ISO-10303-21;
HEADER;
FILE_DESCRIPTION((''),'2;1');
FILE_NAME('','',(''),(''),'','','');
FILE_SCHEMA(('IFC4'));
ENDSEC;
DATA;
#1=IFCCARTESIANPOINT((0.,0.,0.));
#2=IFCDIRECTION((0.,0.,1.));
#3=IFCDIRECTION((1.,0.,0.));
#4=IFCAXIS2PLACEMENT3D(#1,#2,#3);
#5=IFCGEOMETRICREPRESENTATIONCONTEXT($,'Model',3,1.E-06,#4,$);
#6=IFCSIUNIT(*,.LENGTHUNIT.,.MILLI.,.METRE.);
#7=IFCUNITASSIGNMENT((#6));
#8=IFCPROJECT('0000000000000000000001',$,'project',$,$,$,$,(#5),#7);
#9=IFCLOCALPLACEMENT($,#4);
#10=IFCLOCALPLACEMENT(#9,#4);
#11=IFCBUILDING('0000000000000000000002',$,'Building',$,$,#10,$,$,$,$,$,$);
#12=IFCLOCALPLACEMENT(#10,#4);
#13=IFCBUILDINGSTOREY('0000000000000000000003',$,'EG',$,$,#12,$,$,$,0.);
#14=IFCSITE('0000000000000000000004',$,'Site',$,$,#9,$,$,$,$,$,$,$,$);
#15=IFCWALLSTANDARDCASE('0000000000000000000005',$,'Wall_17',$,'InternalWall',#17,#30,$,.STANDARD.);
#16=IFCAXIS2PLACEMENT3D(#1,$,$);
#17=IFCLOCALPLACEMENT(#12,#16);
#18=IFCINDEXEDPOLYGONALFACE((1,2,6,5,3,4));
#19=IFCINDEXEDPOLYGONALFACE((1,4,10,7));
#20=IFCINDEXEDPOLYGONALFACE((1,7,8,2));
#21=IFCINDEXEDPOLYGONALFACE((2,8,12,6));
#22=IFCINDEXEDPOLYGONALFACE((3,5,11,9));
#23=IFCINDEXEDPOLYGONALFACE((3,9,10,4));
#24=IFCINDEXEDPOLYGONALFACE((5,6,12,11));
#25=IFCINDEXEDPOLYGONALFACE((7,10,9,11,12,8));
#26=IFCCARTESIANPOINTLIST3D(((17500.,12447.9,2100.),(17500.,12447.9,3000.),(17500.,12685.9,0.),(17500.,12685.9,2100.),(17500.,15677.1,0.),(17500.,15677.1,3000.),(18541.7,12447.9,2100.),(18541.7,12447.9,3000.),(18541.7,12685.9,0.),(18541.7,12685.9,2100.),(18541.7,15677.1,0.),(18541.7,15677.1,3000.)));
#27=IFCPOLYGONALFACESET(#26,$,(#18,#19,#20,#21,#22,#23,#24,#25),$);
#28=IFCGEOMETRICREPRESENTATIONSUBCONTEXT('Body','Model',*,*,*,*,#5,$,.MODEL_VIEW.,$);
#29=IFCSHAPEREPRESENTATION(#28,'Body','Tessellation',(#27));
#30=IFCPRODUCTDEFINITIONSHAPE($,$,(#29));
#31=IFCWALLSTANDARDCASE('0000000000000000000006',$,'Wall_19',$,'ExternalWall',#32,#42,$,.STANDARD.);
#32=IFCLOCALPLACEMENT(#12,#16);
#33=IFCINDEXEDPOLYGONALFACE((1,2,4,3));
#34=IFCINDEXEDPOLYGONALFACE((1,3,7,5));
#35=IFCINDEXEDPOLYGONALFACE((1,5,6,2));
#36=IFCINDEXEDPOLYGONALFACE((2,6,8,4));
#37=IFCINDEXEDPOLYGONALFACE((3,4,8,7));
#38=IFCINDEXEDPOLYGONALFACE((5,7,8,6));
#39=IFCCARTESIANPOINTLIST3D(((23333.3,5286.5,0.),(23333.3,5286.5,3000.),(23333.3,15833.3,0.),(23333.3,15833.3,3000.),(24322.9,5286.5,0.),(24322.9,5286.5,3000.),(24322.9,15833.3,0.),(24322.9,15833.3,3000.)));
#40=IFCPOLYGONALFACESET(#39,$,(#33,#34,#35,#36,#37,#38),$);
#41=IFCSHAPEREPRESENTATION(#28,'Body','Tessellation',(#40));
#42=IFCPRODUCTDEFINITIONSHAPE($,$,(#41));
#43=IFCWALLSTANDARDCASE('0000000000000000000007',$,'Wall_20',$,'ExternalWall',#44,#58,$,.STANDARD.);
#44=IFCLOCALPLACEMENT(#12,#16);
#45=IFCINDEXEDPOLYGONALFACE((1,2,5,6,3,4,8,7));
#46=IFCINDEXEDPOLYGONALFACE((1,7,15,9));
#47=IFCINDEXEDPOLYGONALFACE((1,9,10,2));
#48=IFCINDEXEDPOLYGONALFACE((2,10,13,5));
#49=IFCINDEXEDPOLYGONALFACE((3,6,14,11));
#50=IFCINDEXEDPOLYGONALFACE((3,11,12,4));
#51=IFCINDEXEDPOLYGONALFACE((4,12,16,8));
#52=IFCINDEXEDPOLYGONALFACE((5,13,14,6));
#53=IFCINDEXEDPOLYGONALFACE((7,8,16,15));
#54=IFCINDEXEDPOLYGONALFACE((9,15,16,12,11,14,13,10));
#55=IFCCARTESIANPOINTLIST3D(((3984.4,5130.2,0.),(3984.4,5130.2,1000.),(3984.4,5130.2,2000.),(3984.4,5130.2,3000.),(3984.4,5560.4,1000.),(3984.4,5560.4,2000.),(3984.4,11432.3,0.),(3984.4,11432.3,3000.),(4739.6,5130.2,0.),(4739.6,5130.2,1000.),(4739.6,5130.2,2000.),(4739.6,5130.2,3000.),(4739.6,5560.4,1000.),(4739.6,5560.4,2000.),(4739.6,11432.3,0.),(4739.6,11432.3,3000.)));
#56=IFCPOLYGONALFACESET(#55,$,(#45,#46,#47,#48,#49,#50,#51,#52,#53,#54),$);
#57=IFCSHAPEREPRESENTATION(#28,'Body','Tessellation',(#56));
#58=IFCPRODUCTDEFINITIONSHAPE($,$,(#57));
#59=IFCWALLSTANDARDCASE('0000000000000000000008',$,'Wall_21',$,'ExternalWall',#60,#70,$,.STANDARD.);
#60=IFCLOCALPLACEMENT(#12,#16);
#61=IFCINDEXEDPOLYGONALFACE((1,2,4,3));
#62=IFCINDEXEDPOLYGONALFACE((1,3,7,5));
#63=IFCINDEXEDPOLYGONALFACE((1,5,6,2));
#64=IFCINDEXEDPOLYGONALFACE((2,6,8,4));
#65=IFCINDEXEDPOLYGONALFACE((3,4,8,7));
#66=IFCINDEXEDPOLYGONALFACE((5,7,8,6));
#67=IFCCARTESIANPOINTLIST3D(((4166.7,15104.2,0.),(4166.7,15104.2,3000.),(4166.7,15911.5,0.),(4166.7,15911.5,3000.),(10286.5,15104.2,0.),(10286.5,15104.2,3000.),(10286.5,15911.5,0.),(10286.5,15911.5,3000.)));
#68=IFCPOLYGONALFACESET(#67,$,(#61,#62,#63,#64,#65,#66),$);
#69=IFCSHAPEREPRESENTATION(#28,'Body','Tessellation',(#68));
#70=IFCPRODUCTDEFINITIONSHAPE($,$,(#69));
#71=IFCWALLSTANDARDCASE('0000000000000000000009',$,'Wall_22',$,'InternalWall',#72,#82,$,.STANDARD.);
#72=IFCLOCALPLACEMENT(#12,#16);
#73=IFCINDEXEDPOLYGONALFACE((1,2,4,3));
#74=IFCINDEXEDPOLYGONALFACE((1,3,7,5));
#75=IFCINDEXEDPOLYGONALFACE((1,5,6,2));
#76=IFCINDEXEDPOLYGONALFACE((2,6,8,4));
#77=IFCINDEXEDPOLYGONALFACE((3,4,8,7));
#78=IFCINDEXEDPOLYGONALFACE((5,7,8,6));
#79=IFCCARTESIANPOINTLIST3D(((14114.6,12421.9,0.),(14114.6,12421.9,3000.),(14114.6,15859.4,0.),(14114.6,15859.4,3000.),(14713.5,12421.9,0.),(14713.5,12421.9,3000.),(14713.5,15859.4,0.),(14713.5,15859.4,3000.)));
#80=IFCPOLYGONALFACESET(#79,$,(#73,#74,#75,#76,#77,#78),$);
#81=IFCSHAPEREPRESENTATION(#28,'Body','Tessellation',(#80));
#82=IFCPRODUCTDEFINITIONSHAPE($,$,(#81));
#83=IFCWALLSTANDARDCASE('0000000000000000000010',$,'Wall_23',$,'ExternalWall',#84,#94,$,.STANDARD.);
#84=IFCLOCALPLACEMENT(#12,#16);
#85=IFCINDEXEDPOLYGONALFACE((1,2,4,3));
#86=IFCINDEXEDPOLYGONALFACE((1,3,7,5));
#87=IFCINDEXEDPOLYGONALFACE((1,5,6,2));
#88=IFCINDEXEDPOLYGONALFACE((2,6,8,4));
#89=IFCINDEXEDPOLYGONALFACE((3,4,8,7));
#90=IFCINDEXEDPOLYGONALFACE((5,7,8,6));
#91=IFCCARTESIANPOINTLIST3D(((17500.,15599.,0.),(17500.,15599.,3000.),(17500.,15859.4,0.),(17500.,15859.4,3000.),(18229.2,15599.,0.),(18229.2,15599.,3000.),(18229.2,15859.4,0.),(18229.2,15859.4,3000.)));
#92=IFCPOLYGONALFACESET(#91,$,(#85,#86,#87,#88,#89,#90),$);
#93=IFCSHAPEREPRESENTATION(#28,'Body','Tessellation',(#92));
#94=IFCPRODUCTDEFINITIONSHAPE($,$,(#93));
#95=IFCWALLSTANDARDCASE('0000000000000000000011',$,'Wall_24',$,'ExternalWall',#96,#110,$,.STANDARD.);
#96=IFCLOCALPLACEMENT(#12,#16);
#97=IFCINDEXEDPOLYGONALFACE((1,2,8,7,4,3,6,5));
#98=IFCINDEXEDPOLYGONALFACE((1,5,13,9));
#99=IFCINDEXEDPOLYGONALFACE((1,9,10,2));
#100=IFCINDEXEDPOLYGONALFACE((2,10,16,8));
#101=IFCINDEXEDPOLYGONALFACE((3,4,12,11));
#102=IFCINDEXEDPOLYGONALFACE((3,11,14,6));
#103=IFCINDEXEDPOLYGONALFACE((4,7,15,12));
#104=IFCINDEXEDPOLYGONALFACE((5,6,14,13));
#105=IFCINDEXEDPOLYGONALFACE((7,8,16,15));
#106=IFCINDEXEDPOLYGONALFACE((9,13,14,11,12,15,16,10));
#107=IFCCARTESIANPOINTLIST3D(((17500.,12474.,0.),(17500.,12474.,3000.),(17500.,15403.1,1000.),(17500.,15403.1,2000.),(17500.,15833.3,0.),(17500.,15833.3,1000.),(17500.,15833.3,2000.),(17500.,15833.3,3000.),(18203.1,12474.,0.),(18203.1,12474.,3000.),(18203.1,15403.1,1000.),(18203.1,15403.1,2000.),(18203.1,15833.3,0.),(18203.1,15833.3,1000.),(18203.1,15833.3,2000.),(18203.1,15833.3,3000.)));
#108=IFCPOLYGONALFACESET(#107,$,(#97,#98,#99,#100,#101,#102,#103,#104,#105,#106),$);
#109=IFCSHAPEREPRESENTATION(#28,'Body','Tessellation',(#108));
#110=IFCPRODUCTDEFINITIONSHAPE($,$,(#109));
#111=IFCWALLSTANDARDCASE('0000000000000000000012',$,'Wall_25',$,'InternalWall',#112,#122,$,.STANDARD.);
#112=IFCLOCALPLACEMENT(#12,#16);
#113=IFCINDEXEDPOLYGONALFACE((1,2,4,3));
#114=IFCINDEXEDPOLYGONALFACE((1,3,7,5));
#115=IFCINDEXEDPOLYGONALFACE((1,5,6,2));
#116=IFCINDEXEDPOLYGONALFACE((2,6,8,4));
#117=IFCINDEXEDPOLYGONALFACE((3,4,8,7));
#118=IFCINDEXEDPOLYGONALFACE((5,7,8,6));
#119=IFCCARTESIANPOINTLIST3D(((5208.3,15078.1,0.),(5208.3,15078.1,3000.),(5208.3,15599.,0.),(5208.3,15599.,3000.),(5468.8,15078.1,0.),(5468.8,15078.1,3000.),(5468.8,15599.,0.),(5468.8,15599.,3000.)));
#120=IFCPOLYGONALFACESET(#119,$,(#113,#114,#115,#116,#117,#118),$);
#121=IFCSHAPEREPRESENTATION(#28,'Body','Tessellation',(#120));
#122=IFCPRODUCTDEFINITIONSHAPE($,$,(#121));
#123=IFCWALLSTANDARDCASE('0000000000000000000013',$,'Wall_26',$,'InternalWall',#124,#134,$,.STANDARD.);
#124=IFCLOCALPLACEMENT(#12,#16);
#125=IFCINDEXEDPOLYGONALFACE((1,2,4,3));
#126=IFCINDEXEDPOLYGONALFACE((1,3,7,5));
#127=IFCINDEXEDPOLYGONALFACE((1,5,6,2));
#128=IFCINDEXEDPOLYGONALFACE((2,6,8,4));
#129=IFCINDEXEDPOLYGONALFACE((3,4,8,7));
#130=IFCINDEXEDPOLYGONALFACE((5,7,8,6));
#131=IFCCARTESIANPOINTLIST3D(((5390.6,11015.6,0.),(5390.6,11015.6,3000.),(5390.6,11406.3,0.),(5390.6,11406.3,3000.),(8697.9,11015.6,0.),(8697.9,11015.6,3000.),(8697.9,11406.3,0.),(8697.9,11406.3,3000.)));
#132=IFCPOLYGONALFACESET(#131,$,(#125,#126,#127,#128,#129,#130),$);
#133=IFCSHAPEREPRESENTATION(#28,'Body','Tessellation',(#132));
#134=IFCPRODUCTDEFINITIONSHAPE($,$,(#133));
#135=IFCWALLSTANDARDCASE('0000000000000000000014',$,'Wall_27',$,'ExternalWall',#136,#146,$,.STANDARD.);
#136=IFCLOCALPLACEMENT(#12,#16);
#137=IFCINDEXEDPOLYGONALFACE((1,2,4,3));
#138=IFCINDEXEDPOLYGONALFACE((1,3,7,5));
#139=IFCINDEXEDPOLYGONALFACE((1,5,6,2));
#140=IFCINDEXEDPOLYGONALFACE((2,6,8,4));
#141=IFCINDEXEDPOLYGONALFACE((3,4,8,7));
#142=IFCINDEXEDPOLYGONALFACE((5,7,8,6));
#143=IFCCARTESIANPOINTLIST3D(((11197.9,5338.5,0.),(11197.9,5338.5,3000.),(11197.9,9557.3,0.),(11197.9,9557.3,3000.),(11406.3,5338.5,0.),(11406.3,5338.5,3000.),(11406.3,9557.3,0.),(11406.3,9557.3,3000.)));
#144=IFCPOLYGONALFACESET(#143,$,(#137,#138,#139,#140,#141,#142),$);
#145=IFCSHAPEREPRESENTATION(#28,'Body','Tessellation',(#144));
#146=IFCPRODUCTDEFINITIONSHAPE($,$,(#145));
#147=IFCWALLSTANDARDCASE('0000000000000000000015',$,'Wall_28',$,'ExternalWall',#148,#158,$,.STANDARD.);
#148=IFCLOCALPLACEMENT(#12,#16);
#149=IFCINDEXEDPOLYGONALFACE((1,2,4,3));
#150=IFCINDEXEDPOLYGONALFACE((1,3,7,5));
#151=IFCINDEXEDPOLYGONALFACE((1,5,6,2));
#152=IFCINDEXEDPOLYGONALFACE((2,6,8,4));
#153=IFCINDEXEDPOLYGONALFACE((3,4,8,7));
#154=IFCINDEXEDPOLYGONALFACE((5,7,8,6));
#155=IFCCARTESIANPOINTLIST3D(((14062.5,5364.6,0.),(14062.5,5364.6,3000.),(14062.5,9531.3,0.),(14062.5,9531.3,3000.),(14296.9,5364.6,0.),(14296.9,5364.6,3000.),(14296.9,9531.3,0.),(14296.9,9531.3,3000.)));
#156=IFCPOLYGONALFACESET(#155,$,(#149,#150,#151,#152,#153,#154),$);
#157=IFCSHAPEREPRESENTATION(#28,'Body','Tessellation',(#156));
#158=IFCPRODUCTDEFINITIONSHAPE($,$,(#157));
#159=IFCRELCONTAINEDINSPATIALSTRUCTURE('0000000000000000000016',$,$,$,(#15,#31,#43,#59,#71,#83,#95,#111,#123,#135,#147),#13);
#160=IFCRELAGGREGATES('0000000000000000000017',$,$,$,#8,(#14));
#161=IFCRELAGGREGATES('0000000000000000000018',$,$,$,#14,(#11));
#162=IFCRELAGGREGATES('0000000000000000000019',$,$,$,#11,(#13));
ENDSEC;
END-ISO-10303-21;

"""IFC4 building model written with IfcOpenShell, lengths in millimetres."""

from ifc_helpers import new_model, si_unit, frame, origin_with_axes, place, context, subcontext, project, spatial, rectangle, extrude, element, save


model = new_model("IFC4")

# Units and contexts
model_context = context("Model", 3, precision=1e-06, world=origin_with_axes())
body_context = subcontext(model_context, "Body", "Model", "MODEL_VIEW")
ifc_project = project(units=[si_unit("LENGTHUNIT", "METRE", prefix="MILLI")], contexts=[model_context])

# Site, building, storey
site_placement = place(None, origin_with_axes())
site = spatial("IfcSite", under=ifc_project, at=site_placement, Name="Site")
building_placement = place(site_placement, origin_with_axes())
building = spatial("IfcBuilding", under=site, at=building_placement, Name="Building")
storey_placement = place(building_placement, origin_with_axes())
storey = spatial("IfcBuildingStorey", under=building, at=storey_placement, Name="EG", Elevation=0.0)

# Wall, opening
wall_1_placement = place(storey_placement, origin_with_axes())
wall_1 = element("IfcWallStandardCase", 1, at=wall_1_placement, inside=storey, Name="Wall_17", ObjectType="InternalWall", PredefinedType="STANDARD", context=body_context, shape_type="SweptSolid", body=[
    extrude(rectangle(XDim=3229.2, YDim=1041.7), frame((18020.8, 14062.5, 0.0), z_axis=(0.0, 0.0, 1.0), x_axis=(0.0, 1.0, 0.0)), (0.0, 0.0, 1.0), 3000.0),
])
opening_1_placement = place(wall_1_placement, origin_with_axes())
element("IfcOpeningElement", 2, at=opening_1_placement, inside=storey, cuts=wall_1, context=body_context, shape_type="SweptSolid", body=[
    extrude(rectangle(XDim=450.0, YDim=1041.7), frame((18020.8, 12460.9, 0.0), z_axis=(0.0, 0.0, 1.0), x_axis=(0.0, 1.0, 0.0)), (0.0, 0.0, 1.0), 2100.0),
])

# Wall
wall_2_placement = place(storey_placement, origin_with_axes())
element("IfcWallStandardCase", 3, at=wall_2_placement, inside=storey, Name="Wall_19", ObjectType="ExternalWall", PredefinedType="STANDARD", context=body_context, shape_type="SweptSolid", body=[
    extrude(rectangle(XDim=10546.9, YDim=989.6), frame((23828.1, 10559.9, 0.0), z_axis=(0.0, 0.0, 1.0), x_axis=(0.0, 1.0, 0.0)), (0.0, 0.0, 1.0), 3000.0),
])

# Wall, opening
wall_3_placement = place(storey_placement, origin_with_axes())
wall_3 = element("IfcWallStandardCase", 4, at=wall_3_placement, inside=storey, Name="Wall_20", ObjectType="ExternalWall", PredefinedType="STANDARD", context=body_context, shape_type="SweptSolid", body=[
    extrude(rectangle(XDim=6302.1, YDim=755.2), frame((4362.0, 8281.3, 0.0), z_axis=(0.0, 0.0, 1.0), x_axis=(0.0, 1.0, 0.0)), (0.0, 0.0, 1.0), 3000.0),
])
opening_2_placement = place(wall_3_placement, origin_with_axes())
element("IfcOpeningElement", 5, at=opening_2_placement, inside=storey, cuts=wall_3, context=body_context, shape_type="SweptSolid", body=[
    extrude(rectangle(XDim=600.0, YDim=755.2), frame((4362.0, 5260.4, 1000.0), z_axis=(0.0, 0.0, 1.0), x_axis=(0.0, 1.0, 0.0)), (0.0, 0.0, 1.0), 1000.0),
])

# Walls
wall_4_placement = place(storey_placement, origin_with_axes())
element("IfcWallStandardCase", 6, at=wall_4_placement, inside=storey, Name="Wall_21", ObjectType="ExternalWall", PredefinedType="STANDARD", context=body_context, shape_type="SweptSolid", body=[
    extrude(rectangle(XDim=6119.8, YDim=807.3), frame((7226.6, 15507.8, 0.0), z_axis=(0.0, 0.0, 1.0), x_axis=(-1.0, 0.0, 0.0)), (0.0, 0.0, 1.0), 3000.0),
])
wall_5_placement = place(storey_placement, origin_with_axes())
element("IfcWallStandardCase", 7, at=wall_5_placement, inside=storey, Name="Wall_22", ObjectType="InternalWall", PredefinedType="STANDARD", context=body_context, shape_type="SweptSolid", body=[
    extrude(rectangle(XDim=3437.5, YDim=599.0), frame((14414.1, 14140.6, 0.0), z_axis=(0.0, 0.0, 1.0), x_axis=(0.0, 1.0, 0.0)), (0.0, 0.0, 1.0), 3000.0),
])
wall_6_placement = place(storey_placement, origin_with_axes())
element("IfcWallStandardCase", 8, at=wall_6_placement, inside=storey, Name="Wall_23", ObjectType="ExternalWall", PredefinedType="STANDARD", context=body_context, shape_type="SweptSolid", body=[
    extrude(rectangle(XDim=729.2, YDim=260.4), frame((17864.6, 15729.2, 0.0), z_axis=(0.0, 0.0, 1.0), x_axis=(1.0, 0.0, 0.0)), (0.0, 0.0, 1.0), 3000.0),
])

# Wall, opening
wall_7_placement = place(storey_placement, origin_with_axes())
wall_7 = element("IfcWallStandardCase", 9, at=wall_7_placement, inside=storey, Name="Wall_24", ObjectType="ExternalWall", PredefinedType="STANDARD", context=body_context, shape_type="SweptSolid", body=[
    extrude(rectangle(XDim=3359.4, YDim=703.1), frame((17851.6, 14153.6, 0.0), z_axis=(0.0, 0.0, 1.0), x_axis=(0.0, 1.0, 0.0)), (0.0, 0.0, 1.0), 3000.0),
])
opening_3_placement = place(wall_7_placement, origin_with_axes())
element("IfcOpeningElement", 10, at=opening_3_placement, inside=storey, cuts=wall_7, context=body_context, shape_type="SweptSolid", body=[
    extrude(rectangle(XDim=600.0, YDim=703.1), frame((17851.6, 15703.1, 1000.0), z_axis=(0.0, 0.0, 1.0), x_axis=(0.0, 1.0, 0.0)), (0.0, 0.0, 1.0), 1000.0),
])

# Walls
wall_8_placement = place(storey_placement, origin_with_axes())
element("IfcWallStandardCase", 11, at=wall_8_placement, inside=storey, Name="Wall_25", ObjectType="InternalWall", PredefinedType="STANDARD", context=body_context, shape_type="SweptSolid", body=[
    extrude(rectangle(XDim=520.8, YDim=260.4), frame((5338.5, 15338.5, 0.0), z_axis=(0.0, 0.0, 1.0), x_axis=(0.0, 1.0, 0.0)), (0.0, 0.0, 1.0), 3000.0),
])
wall_9_placement = place(storey_placement, origin_with_axes())
element("IfcWallStandardCase", 12, at=wall_9_placement, inside=storey, Name="Wall_26", ObjectType="InternalWall", PredefinedType="STANDARD", context=body_context, shape_type="SweptSolid", body=[
    extrude(rectangle(XDim=3307.3, YDim=390.6), frame((7044.3, 11210.9, 0.0), z_axis=(0.0, 0.0, 1.0), x_axis=(1.0, 0.0, 0.0)), (0.0, 0.0, 1.0), 3000.0),
])
wall_10_placement = place(storey_placement, origin_with_axes())
element("IfcWallStandardCase", 13, at=wall_10_placement, inside=storey, Name="Wall_27", ObjectType="ExternalWall", PredefinedType="STANDARD", context=body_context, shape_type="SweptSolid", body=[
    extrude(rectangle(XDim=4218.8, YDim=208.3), frame((11302.1, 7447.9, 0.0), z_axis=(0.0, 0.0, 1.0), x_axis=(0.0, 1.0, 0.0)), (0.0, 0.0, 1.0), 3000.0),
])
wall_11_placement = place(storey_placement, origin_with_axes())
element("IfcWallStandardCase", 14, at=wall_11_placement, inside=storey, Name="Wall_28", ObjectType="ExternalWall", PredefinedType="STANDARD", context=body_context, shape_type="SweptSolid", body=[
    extrude(rectangle(XDim=4166.7, YDim=234.4), frame((14179.7, 7447.9, 0.0), z_axis=(0.0, 0.0, 1.0), x_axis=(0.0, 1.0, 0.0)), (0.0, 0.0, 1.0), 3000.0),
])

save(model, "model.ifc")
